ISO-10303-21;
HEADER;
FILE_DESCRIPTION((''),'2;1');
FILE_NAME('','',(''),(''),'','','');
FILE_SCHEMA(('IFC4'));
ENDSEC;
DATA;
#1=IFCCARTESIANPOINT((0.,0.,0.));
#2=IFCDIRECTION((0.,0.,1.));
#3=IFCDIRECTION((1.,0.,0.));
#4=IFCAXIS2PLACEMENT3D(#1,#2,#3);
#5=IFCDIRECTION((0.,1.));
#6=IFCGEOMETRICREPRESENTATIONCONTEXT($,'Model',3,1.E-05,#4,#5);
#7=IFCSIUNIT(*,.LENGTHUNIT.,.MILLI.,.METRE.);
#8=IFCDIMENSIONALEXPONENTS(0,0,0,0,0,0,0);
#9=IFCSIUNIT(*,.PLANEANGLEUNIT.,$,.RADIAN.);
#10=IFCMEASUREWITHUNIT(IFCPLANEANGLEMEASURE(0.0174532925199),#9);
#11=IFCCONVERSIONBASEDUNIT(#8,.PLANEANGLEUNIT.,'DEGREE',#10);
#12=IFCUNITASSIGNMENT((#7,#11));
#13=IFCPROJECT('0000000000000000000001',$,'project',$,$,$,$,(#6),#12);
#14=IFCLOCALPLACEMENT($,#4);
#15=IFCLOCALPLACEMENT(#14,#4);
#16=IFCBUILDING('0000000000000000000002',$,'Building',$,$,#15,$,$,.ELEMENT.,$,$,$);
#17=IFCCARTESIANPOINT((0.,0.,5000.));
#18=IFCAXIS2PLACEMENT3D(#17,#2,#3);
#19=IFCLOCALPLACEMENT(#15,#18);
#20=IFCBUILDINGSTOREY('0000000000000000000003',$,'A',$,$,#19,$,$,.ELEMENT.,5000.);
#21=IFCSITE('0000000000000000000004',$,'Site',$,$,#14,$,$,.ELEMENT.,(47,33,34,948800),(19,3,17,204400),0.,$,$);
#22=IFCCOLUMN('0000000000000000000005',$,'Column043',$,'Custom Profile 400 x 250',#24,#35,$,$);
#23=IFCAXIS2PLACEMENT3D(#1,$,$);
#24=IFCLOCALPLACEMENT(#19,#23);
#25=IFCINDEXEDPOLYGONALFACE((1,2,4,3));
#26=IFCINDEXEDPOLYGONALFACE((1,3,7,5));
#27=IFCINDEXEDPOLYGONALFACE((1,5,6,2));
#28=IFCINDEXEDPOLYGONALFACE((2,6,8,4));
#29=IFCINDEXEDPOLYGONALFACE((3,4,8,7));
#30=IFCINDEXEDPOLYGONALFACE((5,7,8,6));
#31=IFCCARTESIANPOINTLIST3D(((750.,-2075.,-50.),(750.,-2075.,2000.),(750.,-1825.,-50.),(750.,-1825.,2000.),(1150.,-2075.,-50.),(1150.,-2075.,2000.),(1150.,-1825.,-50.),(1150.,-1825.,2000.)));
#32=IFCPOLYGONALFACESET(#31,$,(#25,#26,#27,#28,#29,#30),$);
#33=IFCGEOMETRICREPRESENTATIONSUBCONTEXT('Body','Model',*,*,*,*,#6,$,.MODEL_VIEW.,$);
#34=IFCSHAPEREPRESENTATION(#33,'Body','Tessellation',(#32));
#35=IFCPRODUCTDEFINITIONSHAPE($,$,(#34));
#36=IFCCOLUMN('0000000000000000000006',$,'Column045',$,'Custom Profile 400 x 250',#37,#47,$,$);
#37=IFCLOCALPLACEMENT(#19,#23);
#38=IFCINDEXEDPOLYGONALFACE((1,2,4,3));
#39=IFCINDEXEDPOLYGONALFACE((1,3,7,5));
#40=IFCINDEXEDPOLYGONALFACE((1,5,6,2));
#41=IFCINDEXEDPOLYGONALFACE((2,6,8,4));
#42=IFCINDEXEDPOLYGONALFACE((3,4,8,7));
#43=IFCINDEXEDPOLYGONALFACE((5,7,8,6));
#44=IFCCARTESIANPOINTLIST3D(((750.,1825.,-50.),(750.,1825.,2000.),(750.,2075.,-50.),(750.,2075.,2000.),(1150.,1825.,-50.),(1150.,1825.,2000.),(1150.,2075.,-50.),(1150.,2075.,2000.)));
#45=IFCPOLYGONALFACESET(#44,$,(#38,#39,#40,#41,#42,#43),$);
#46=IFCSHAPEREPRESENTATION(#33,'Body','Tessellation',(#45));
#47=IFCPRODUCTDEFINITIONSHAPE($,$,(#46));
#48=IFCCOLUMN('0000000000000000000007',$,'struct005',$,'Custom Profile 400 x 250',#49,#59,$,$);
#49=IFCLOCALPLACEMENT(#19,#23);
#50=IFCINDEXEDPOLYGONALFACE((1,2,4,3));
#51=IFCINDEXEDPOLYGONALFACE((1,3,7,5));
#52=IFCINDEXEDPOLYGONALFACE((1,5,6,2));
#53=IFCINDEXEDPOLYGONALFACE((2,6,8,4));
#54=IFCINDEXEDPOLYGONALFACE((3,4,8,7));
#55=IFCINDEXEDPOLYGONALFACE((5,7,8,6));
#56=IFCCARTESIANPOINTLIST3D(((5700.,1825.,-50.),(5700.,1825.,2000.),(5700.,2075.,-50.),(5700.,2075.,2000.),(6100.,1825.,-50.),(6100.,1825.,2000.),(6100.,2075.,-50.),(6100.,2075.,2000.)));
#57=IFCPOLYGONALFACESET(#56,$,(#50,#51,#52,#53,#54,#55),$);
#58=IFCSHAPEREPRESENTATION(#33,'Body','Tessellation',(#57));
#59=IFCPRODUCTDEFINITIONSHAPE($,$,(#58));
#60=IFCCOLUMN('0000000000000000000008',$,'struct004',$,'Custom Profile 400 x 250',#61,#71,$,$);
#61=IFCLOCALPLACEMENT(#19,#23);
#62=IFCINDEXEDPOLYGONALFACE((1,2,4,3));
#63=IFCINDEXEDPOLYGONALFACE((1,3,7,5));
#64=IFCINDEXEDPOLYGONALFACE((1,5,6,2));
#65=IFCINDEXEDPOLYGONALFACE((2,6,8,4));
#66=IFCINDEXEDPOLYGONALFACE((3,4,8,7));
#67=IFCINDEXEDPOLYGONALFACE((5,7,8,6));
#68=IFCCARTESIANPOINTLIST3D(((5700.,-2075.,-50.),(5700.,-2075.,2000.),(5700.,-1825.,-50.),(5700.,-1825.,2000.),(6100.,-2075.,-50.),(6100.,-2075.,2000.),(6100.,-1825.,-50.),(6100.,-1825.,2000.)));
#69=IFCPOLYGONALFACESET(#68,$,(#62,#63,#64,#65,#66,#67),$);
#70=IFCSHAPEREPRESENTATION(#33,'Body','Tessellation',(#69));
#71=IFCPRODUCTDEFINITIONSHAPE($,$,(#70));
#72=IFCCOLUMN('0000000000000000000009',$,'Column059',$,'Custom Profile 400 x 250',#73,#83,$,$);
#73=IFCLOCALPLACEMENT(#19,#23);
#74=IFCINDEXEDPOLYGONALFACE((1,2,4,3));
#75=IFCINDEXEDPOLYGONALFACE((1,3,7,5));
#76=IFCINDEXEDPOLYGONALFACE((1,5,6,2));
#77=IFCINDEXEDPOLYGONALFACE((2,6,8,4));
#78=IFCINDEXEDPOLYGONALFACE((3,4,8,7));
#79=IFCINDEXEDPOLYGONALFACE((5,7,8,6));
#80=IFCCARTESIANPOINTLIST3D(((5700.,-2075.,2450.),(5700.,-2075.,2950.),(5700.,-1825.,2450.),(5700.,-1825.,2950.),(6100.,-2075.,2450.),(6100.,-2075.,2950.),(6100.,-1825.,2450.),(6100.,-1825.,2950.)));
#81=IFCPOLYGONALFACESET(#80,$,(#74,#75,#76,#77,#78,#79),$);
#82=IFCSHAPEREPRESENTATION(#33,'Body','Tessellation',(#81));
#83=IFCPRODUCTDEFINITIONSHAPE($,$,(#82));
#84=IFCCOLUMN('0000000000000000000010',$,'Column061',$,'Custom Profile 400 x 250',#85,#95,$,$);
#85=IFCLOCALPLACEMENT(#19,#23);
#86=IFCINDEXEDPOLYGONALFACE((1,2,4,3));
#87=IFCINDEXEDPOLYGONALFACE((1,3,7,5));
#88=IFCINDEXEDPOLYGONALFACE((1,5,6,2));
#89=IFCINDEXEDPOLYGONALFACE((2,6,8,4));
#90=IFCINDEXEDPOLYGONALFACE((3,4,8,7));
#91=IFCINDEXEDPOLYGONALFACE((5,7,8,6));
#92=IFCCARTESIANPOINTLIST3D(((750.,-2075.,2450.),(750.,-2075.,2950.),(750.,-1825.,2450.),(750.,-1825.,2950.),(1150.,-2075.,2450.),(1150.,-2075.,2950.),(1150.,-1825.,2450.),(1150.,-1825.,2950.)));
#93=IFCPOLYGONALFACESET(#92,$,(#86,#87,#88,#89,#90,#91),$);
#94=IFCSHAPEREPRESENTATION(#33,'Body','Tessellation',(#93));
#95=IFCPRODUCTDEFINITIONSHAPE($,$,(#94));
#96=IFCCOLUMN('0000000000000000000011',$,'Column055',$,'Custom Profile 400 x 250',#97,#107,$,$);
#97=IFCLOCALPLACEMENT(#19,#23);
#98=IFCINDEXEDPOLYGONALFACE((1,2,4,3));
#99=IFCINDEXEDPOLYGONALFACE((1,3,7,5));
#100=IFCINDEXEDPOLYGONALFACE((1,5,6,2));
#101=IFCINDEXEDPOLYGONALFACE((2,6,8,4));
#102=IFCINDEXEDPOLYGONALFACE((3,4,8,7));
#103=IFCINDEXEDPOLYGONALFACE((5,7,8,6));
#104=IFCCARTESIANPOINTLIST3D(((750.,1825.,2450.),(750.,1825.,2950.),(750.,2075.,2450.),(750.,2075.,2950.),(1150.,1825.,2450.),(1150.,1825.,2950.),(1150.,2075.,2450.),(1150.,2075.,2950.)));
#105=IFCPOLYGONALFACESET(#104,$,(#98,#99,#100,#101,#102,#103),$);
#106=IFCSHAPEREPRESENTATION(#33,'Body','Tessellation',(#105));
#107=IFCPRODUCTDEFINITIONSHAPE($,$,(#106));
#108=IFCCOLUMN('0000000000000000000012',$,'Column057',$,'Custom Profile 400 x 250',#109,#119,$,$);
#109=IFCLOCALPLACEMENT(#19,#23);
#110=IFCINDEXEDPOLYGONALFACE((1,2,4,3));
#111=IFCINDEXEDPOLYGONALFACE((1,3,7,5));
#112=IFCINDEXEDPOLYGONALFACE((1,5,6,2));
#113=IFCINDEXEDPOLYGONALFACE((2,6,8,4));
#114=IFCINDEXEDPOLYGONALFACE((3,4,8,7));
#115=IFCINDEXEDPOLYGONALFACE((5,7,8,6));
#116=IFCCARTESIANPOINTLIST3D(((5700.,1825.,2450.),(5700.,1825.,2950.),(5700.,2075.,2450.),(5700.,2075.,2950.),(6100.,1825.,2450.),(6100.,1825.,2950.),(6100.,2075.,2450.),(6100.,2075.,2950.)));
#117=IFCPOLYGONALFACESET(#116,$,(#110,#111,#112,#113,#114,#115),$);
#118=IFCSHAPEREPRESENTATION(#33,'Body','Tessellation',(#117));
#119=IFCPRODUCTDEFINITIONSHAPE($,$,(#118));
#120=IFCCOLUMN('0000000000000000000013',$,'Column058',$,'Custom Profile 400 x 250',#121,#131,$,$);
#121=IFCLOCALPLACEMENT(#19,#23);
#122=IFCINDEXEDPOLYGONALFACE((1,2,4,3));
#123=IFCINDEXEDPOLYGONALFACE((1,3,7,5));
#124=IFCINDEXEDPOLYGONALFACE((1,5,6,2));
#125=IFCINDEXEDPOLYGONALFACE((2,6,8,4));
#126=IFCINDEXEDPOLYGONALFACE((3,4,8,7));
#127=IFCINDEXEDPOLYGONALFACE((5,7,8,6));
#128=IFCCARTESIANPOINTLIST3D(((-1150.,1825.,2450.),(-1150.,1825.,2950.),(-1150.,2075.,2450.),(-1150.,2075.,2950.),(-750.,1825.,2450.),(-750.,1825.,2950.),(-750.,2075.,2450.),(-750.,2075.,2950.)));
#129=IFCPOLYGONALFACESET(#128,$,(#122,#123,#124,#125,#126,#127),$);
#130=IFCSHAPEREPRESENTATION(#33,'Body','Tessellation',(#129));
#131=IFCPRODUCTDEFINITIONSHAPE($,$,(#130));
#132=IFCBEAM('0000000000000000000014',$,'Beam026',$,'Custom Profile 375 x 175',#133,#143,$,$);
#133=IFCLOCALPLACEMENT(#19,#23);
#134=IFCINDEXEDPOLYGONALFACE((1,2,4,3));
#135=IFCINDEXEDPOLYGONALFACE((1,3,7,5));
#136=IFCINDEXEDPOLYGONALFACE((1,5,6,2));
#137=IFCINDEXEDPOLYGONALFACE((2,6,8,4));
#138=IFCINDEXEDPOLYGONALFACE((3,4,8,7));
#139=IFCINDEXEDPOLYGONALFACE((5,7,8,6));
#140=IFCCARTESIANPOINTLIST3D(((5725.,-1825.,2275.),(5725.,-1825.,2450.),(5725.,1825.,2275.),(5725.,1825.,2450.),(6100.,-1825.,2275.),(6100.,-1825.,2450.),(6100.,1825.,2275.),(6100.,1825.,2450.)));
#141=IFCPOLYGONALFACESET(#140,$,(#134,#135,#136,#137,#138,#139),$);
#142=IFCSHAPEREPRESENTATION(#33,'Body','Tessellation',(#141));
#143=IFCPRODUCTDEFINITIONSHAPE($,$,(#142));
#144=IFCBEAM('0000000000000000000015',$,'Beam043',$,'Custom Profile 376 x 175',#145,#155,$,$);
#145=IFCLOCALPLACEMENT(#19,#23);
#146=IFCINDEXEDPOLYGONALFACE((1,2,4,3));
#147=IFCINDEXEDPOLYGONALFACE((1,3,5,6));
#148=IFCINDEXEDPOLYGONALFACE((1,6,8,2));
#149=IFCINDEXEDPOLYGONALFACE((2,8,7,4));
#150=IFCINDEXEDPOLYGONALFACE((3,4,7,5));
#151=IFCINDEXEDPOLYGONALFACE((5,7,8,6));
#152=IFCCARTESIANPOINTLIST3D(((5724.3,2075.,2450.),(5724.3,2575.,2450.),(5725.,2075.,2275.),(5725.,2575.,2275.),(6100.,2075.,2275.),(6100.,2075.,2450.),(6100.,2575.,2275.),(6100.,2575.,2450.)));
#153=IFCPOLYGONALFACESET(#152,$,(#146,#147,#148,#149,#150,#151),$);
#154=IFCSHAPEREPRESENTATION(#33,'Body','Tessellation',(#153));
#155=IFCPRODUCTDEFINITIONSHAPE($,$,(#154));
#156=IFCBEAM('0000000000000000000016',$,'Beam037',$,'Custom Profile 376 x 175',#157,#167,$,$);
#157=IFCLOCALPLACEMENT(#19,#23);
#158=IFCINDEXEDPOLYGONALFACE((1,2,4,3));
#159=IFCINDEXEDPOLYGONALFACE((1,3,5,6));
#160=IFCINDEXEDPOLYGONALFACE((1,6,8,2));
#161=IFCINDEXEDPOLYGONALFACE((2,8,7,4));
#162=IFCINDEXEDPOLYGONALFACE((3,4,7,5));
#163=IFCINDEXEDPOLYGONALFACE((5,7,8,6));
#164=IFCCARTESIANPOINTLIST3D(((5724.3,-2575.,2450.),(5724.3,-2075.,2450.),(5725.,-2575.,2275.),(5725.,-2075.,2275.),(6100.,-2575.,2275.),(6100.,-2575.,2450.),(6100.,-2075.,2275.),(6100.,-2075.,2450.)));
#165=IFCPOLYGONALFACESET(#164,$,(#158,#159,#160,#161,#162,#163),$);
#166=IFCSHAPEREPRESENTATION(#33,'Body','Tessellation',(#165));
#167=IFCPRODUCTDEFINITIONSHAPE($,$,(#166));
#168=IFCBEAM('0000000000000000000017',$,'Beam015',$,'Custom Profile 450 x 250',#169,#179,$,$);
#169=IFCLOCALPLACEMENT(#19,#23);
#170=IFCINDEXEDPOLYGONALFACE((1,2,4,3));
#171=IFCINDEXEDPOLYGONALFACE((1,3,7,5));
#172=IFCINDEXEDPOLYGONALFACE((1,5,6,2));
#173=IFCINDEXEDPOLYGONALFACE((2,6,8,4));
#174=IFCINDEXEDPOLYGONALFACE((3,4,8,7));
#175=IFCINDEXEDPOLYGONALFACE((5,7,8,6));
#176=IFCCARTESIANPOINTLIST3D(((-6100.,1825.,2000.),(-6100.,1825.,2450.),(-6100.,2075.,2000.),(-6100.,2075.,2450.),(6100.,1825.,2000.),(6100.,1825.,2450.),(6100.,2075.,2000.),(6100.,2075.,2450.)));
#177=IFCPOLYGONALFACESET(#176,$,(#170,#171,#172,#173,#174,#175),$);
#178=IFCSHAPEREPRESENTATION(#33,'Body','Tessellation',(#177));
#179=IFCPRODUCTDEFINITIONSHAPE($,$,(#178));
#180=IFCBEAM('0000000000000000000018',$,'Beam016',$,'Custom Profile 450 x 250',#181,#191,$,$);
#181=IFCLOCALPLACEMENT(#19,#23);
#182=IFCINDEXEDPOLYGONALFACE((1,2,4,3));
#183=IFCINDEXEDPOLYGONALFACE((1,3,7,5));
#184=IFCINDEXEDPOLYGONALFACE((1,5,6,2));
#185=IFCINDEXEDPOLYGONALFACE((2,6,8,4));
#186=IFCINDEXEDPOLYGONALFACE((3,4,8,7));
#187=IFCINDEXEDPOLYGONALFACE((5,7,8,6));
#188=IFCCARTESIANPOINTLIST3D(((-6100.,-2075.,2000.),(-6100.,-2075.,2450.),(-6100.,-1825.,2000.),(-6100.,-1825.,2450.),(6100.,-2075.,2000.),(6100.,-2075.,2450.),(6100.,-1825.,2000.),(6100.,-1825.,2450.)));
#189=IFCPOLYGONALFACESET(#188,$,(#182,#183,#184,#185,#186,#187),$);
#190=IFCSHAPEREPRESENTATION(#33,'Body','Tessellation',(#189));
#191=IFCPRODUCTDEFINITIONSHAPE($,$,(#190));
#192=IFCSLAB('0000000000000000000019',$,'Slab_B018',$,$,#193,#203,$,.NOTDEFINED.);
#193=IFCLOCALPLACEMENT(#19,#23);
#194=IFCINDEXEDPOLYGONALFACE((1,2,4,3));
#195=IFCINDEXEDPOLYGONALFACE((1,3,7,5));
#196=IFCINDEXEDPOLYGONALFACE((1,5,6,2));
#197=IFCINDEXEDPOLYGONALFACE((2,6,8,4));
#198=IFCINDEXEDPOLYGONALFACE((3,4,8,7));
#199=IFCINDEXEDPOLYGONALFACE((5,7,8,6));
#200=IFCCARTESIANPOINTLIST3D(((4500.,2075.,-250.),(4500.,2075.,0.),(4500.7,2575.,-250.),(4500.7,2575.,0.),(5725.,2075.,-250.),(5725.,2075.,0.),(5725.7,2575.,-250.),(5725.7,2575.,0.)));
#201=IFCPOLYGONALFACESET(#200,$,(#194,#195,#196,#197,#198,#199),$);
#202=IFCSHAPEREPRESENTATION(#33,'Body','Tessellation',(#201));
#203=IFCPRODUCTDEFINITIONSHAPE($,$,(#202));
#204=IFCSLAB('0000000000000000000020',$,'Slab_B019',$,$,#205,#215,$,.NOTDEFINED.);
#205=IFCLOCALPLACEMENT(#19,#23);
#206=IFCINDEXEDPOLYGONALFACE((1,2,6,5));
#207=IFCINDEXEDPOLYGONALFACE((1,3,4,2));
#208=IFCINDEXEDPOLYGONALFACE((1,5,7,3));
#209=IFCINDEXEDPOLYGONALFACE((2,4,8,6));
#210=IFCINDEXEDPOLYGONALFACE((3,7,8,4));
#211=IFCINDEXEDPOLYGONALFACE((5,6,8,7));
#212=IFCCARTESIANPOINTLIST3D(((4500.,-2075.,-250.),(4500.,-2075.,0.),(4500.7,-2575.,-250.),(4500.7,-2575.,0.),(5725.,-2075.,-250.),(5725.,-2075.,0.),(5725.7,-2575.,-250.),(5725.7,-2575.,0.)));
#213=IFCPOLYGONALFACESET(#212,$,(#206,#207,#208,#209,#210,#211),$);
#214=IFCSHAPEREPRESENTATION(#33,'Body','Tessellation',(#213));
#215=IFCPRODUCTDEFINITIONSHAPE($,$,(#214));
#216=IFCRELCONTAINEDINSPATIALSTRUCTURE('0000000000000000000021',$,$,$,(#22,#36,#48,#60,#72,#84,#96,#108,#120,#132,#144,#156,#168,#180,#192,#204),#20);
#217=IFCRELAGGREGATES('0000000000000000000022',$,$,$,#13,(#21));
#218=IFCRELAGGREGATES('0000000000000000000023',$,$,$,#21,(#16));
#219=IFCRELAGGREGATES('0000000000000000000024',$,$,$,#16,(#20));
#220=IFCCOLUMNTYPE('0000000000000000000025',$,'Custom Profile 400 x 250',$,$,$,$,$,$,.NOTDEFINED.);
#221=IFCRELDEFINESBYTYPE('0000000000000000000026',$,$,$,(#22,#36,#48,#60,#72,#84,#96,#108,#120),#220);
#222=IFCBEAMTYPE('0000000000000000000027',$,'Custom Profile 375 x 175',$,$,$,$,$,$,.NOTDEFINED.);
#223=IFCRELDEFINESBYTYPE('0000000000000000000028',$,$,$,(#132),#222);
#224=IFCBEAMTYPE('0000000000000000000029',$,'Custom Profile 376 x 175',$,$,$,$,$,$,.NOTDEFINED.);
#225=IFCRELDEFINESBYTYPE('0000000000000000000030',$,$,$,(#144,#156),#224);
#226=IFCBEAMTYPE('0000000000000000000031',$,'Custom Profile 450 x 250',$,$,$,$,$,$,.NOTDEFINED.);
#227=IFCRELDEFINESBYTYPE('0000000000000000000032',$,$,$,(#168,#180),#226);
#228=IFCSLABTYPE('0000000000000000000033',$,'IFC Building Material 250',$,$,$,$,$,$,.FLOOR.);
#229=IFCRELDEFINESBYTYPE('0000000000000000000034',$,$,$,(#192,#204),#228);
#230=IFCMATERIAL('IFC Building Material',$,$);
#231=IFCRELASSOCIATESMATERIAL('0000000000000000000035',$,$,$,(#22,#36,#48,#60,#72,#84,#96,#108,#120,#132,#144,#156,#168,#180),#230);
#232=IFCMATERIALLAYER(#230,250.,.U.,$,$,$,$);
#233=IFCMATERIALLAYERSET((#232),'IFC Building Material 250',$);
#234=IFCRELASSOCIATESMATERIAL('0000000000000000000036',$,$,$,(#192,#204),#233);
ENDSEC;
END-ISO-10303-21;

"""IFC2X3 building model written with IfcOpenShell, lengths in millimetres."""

from ifc_helpers import new_model, entity, si_unit, converted_unit, direction, frame, origin_with_axes, place, context, subcontext, project, spatial, polyline, outline, extrude, material, layer, layer_set, layer_usage, type_object, element, save


model = new_model("IFC2X3")

# Units and contexts
model_context = context("Model", 3, precision=1e-05, world=origin_with_axes(), true_north=direction((0.0, 1.0)))
body_context = subcontext(model_context, "Body", "Model", "MODEL_VIEW")
ifc_project = project(units=[si_unit("LENGTHUNIT", "METRE", prefix="MILLI"), converted_unit("PLANEANGLEUNIT", "DEGREE", entity("IfcPlaneAngleMeasure", 0.0174532925199), si_unit("PLANEANGLEUNIT", "RADIAN"), dimensions=[0, 0, 0, 0, 0, 0, 0])], contexts=[model_context])

# Site, building, storey
site_placement = place(None, origin_with_axes())
site = spatial("IfcSite", under=ifc_project, at=site_placement, Name="Site", CompositionType="ELEMENT", RefLatitude=(47, 33, 34, 948800), RefLongitude=(19, 3, 17, 204400), RefElevation=0.0)
building_placement = place(site_placement, origin_with_axes())
building = spatial("IfcBuilding", under=site, at=building_placement, Name="Building", CompositionType="ELEMENT")
storey_placement = place(building_placement, frame((0.0, 0.0, 5000.0), z_axis=(0.0, 0.0, 1.0), x_axis=(1.0, 0.0, 0.0)))
storey = spatial("IfcBuildingStorey", under=building, at=storey_placement, Name="A", CompositionType="ELEMENT", Elevation=5000.0)

# Columns
ifc_material = material(Name="IFC Building Material")
column_type = type_object("IfcColumnType", Name="Custom Profile 400 x 250", PredefinedType="NOTDEFINED")
for number, where, z_axis, x_axis, name in (
    (1, (950.0, -1950.0, -50.0), (0.0, 0.0, 1.0), (1.0, 0.0, 0.0), "Column043"),
    (2, (950.0, 1950.0, -50.0), (0.0, 0.0, 1.0), (1.0, 0.0, 0.0), "Column045"),
    (3, (5900.0, 1950.0, -50.0), (0.0, 0.0, 1.0), (1.0, 0.0, 0.0), "struct005"),
    (4, (5900.0, -1950.0, -50.0), (0.0, 0.0, 1.0), (1.0, 0.0, 0.0), "struct004"),
):
    element("IfcColumn", number, at=place(storey_placement, frame(where, z_axis=z_axis, x_axis=x_axis)), inside=storey, type_object=column_type, material=ifc_material, Name=name, ObjectType="Custom Profile 400 x 250", context=body_context, shape_type="SweptSolid", body=[
        extrude(outline(polyline([(-200.0, -125.0), (200.0, -125.0), (200.0, 125.0), (-200.0, 125.0), (-200.0, -125.0)])), origin_with_axes(), (0.0, 0.0, 1.0), 2050.0),
    ])
for number, where, z_axis, x_axis, name in (
    (5, (5900.0, -1950.0, 2450.0), (0.0, 0.0, 1.0), (1.0, 0.0, 0.0), "Column059"),
    (6, (950.0, -1950.0, 2450.0), (0.0, 0.0, 1.0), (1.0, 0.0, 0.0), "Column061"),
    (7, (950.0, 1950.0, 2450.0), (0.0, 0.0, 1.0), (1.0, 0.0, 0.0), "Column055"),
    (8, (5900.0, 1950.0, 2450.0), (0.0, 0.0, 1.0), (1.0, 0.0, 0.0), "Column057"),
    (9, (-950.0, 1950.0, 2450.0), (0.0, 0.0, 1.0), (1.0, 0.0, 0.0), "Column058"),
):
    element("IfcColumn", number, at=place(storey_placement, frame(where, z_axis=z_axis, x_axis=x_axis)), inside=storey, type_object=column_type, material=ifc_material, Name=name, ObjectType="Custom Profile 400 x 250", context=body_context, shape_type="SweptSolid", body=[
        extrude(outline(polyline([(-200.0, -125.0), (200.0, -125.0), (200.0, 125.0), (-200.0, 125.0), (-200.0, -125.0)])), origin_with_axes(), (0.0, 0.0, 1.0), 500.0),
    ])

# Beams
beam_type_1 = type_object("IfcBeamType", Name="Custom Profile 375 x 175", PredefinedType="NOTDEFINED")
beam_placement = place(storey_placement, frame((5912.7, -1825.0, 2362.5), z_axis=(0.0, 0.0, 1.0), x_axis=(1.0, 0.0, 0.0)))
element("IfcBeam", 10, at=beam_placement, inside=storey, type_object=beam_type_1, material=ifc_material, Name="Beam026", ObjectType="Custom Profile 375 x 175", context=body_context, shape_type="SweptSolid", body=[
    extrude(outline(polyline([(-187.7, -87.5), (187.3, -87.5), (187.3, 87.5), (-187.7, 87.5), (-187.7, -87.5)])), frame((0.0, 3650.0, 0.0), z_axis=(0.0, -1.0, 0.0), x_axis=(1.0, 0.0, 0.0)), (0.0, 0.0, 1.0), 3650.0),
])
beam_type_2 = type_object("IfcBeamType", Name="Custom Profile 376 x 175", PredefinedType="NOTDEFINED")
for number, where, z_axis, x_axis, name in (
    (11, (5912.3, 2575.0, 2362.5), (0.0, 0.0, 1.0), (-1.0, 0.0, 0.0), "Beam043"),
    (12, (5912.3, -2075.0, 2362.5), (0.0, 0.0, 1.0), (-1.0, 0.0, 0.0), "Beam037"),
):
    element("IfcBeam", number, at=place(storey_placement, frame(where, z_axis=z_axis, x_axis=x_axis)), inside=storey, type_object=beam_type_2, material=ifc_material, Name=name, ObjectType="Custom Profile 376 x 175", context=body_context, shape_type="SweptSolid", body=[
        extrude(outline(polyline([(-187.7, 87.5), (-187.7, -87.5), (187.3, -87.5), (188.0, 87.5), (-187.7, 87.5)])), frame((0.0, 500.0, 0.0), z_axis=(0.0, -1.0, 0.0), x_axis=(1.0, 0.0, 0.0)), (0.0, 0.0, 1.0), 500.0),
    ])
beam_type_3 = type_object("IfcBeamType", Name="Custom Profile 450 x 250", PredefinedType="NOTDEFINED")
for number, where, z_axis, x_axis, name in (
    (13, (6100.0, 1950.0, 2225.0), (0.0, 0.0, 1.0), (0.0, 1.0, 0.0), "Beam015"),
    (14, (6100.0, -1950.0, 2225.0), (0.0, 0.0, 1.0), (0.0, 1.0, 0.0), "Beam016"),
):
    element("IfcBeam", number, at=place(storey_placement, frame(where, z_axis=z_axis, x_axis=x_axis)), inside=storey, type_object=beam_type_3, material=ifc_material, Name=name, ObjectType="Custom Profile 450 x 250", context=body_context, shape_type="SweptSolid", body=[
        extrude(outline(polyline([(-125.0, -225.0), (125.0, -225.0), (125.0, 225.0), (-125.0, 225.0), (-125.0, -225.0)])), frame((0.0, 12200.0, 0.0), z_axis=(0.0, -1.0, 0.0), x_axis=(1.0, 0.0, 0.0)), (0.0, 0.0, 1.0), 12200.0),
    ])

# Slabs
ifc_layer_1 = layer(ifc_material, 250.0, ventilated="UNKNOWN")
ifc_layer_set_1 = layer_set([ifc_layer_1], Name="IFC Building Material 250")
ifc_layer_usage_1 = layer_usage(ifc_layer_set_1, "AXIS3", "NEGATIVE", 250.0)
slab_type_1 = type_object("IfcSlabType", Name="IFC Building Material 250", PredefinedType="FLOOR")
slab_1_placement = place(storey_placement, frame((4500.0, 2075.0, 0.0), z_axis=(0.0, 0.0, 1.0), x_axis=(1.0, 0.0, 0.0)))
element("IfcSlab", 15, at=slab_1_placement, inside=storey, type_object=slab_type_1, material=ifc_layer_usage_1, Name="Slab_B018", PredefinedType="NOTDEFINED", context=body_context, shape_type="SweptSolid", body=[
    extrude(outline(polyline([(0.0, 0.0), (1225.0, 0.0), (1225.7, 500.0), (0.7, 500.0), (0.0, 0.0)])), frame((0.0, 0.0, -250.0), z_axis=(0.0, 0.0, 1.0), x_axis=(1.0, 0.0, 0.0)), (0.0, 0.0, 1.0), 250.0),
])
ifc_layer_usage_2 = layer_usage(ifc_layer_set_1, "AXIS3", "NEGATIVE", 250.0)
slab_2_placement = place(storey_placement, frame((4500.0, -2075.0, 0.0), z_axis=(0.0, 0.0, 1.0), x_axis=(1.0, 0.0, 0.0)))
element("IfcSlab", 16, at=slab_2_placement, inside=storey, type_object=slab_type_1, material=ifc_layer_usage_2, Name="Slab_B019", PredefinedType="NOTDEFINED", context=body_context, shape_type="SweptSolid", body=[
    extrude(outline(polyline([(0.0, 0.0), (0.7, -500.0), (1225.7, -500.0), (1225.0, 0.0), (0.0, 0.0)])), frame((0.0, 0.0, -250.0), z_axis=(0.0, 0.0, 1.0), x_axis=(1.0, 0.0, 0.0)), (0.0, 0.0, 1.0), 250.0),
])

save(model, "model.ifc")
